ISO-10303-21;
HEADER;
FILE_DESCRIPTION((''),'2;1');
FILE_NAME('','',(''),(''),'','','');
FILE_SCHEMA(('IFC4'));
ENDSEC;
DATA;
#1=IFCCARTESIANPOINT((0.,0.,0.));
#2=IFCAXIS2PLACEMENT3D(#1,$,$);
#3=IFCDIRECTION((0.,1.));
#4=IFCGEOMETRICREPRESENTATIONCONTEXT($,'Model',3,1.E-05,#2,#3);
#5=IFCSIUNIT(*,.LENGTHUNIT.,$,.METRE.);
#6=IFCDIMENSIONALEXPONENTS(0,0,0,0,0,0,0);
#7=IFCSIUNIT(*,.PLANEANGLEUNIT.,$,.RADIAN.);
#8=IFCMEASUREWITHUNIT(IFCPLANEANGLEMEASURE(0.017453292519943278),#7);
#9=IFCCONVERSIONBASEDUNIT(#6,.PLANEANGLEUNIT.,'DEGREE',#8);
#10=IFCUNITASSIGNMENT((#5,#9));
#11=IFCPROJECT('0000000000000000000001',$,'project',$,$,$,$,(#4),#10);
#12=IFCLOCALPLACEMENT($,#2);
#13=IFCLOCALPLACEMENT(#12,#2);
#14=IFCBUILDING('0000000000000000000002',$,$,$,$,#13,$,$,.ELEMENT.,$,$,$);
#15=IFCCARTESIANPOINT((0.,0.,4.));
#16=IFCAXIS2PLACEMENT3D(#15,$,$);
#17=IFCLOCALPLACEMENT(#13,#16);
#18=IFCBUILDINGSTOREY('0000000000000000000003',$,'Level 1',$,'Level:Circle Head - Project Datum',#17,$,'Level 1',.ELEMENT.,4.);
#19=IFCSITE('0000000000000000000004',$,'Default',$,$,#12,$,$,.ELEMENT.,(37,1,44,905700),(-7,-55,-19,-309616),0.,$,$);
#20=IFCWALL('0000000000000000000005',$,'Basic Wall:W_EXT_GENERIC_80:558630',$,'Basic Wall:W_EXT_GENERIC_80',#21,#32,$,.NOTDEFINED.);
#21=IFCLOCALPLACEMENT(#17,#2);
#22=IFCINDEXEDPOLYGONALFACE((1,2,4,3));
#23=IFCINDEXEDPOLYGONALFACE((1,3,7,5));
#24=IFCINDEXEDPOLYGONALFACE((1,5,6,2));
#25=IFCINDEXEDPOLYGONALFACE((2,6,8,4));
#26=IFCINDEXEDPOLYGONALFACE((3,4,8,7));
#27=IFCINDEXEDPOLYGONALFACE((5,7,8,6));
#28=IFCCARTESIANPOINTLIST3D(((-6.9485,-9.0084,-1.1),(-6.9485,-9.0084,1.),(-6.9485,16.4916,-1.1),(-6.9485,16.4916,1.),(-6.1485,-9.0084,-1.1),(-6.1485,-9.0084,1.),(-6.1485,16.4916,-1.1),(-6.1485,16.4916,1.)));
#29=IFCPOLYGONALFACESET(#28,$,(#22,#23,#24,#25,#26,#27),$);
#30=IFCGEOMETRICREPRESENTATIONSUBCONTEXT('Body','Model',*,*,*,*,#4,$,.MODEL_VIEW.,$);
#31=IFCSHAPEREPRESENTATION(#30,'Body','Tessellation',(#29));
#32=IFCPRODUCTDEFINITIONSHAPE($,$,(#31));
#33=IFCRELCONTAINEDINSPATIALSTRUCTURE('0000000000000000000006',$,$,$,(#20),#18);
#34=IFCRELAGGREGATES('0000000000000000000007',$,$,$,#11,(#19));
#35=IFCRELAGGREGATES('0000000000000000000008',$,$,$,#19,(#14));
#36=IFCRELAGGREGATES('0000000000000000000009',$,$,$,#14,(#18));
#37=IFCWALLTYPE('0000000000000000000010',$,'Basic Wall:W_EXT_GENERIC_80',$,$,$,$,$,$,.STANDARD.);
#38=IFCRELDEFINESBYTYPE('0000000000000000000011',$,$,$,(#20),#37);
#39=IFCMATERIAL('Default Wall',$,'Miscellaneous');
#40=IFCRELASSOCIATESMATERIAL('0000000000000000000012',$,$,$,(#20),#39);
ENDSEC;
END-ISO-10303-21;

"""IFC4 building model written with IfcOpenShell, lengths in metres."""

from ifc_helpers import new_model, entity, si_unit, converted_unit, direction, frame, origin, place, context, subcontext, project, spatial, indexed_curve, outline, extrude, material, type_object, element, save


model = new_model("IFC4")

# Units and contexts
model_context = context("Model", 3, precision=1e-05, world=origin(), true_north=direction((0.0, 1.0)))
body_context = subcontext(model_context, "Body", "Model", "MODEL_VIEW")
ifc_project = project(units=[si_unit("LENGTHUNIT", "METRE"), converted_unit("PLANEANGLEUNIT", "DEGREE", entity("IfcPlaneAngleMeasure", 0.017453292519943278), si_unit("PLANEANGLEUNIT", "RADIAN"), dimensions=[0, 0, 0, 0, 0, 0, 0])], contexts=[model_context])

# Site, building, storey
site_placement = place(None, origin())
site = spatial("IfcSite", under=ifc_project, at=site_placement, Name="Default", CompositionType="ELEMENT", RefLatitude=(37, 1, 44, 905700), RefLongitude=(-7, -55, -19, -309616), RefElevation=0.0)
building_placement = place(site_placement, origin())
building = spatial("IfcBuilding", under=site, at=building_placement, CompositionType="ELEMENT")
storey_placement = place(building_placement, frame((0.0, 0.0, 4.0)))
storey = spatial("IfcBuildingStorey", under=building, at=storey_placement, Name="Level 1", ObjectType="Level:Circle Head - Project Datum", LongName="Level 1", CompositionType="ELEMENT", Elevation=4.0)

# Wall
ifc_material_1 = material(Name="Default Wall", Category="Miscellaneous")
wall_type = type_object("IfcWallType", Name="Basic Wall:W_EXT_GENERIC_80", PredefinedType="STANDARD")
wall_placement = place(storey_placement, frame((-6.5485, 16.4916, -1.1), z_axis=(0.0, 0.0, 1.0), x_axis=(0.0, -1.0, 0.0)))
element("IfcWall", 1, at=wall_placement, inside=storey, type_object=wall_type, material=ifc_material_1, Name="Basic Wall:W_EXT_GENERIC_80:558630", ObjectType="Basic Wall:W_EXT_GENERIC_80", PredefinedType="NOTDEFINED", context=body_context, shape_type="SweptSolid", body=[
    extrude(outline(indexed_curve([(25.5, 0.4), (0.0, 0.4), (0.0, -0.4), (25.5, -0.4), (25.5, 0.4)], self_intersect=False)), origin(), (0.0, 0.0, 1.0), 2.1),
])

save(model, "model.ifc")
